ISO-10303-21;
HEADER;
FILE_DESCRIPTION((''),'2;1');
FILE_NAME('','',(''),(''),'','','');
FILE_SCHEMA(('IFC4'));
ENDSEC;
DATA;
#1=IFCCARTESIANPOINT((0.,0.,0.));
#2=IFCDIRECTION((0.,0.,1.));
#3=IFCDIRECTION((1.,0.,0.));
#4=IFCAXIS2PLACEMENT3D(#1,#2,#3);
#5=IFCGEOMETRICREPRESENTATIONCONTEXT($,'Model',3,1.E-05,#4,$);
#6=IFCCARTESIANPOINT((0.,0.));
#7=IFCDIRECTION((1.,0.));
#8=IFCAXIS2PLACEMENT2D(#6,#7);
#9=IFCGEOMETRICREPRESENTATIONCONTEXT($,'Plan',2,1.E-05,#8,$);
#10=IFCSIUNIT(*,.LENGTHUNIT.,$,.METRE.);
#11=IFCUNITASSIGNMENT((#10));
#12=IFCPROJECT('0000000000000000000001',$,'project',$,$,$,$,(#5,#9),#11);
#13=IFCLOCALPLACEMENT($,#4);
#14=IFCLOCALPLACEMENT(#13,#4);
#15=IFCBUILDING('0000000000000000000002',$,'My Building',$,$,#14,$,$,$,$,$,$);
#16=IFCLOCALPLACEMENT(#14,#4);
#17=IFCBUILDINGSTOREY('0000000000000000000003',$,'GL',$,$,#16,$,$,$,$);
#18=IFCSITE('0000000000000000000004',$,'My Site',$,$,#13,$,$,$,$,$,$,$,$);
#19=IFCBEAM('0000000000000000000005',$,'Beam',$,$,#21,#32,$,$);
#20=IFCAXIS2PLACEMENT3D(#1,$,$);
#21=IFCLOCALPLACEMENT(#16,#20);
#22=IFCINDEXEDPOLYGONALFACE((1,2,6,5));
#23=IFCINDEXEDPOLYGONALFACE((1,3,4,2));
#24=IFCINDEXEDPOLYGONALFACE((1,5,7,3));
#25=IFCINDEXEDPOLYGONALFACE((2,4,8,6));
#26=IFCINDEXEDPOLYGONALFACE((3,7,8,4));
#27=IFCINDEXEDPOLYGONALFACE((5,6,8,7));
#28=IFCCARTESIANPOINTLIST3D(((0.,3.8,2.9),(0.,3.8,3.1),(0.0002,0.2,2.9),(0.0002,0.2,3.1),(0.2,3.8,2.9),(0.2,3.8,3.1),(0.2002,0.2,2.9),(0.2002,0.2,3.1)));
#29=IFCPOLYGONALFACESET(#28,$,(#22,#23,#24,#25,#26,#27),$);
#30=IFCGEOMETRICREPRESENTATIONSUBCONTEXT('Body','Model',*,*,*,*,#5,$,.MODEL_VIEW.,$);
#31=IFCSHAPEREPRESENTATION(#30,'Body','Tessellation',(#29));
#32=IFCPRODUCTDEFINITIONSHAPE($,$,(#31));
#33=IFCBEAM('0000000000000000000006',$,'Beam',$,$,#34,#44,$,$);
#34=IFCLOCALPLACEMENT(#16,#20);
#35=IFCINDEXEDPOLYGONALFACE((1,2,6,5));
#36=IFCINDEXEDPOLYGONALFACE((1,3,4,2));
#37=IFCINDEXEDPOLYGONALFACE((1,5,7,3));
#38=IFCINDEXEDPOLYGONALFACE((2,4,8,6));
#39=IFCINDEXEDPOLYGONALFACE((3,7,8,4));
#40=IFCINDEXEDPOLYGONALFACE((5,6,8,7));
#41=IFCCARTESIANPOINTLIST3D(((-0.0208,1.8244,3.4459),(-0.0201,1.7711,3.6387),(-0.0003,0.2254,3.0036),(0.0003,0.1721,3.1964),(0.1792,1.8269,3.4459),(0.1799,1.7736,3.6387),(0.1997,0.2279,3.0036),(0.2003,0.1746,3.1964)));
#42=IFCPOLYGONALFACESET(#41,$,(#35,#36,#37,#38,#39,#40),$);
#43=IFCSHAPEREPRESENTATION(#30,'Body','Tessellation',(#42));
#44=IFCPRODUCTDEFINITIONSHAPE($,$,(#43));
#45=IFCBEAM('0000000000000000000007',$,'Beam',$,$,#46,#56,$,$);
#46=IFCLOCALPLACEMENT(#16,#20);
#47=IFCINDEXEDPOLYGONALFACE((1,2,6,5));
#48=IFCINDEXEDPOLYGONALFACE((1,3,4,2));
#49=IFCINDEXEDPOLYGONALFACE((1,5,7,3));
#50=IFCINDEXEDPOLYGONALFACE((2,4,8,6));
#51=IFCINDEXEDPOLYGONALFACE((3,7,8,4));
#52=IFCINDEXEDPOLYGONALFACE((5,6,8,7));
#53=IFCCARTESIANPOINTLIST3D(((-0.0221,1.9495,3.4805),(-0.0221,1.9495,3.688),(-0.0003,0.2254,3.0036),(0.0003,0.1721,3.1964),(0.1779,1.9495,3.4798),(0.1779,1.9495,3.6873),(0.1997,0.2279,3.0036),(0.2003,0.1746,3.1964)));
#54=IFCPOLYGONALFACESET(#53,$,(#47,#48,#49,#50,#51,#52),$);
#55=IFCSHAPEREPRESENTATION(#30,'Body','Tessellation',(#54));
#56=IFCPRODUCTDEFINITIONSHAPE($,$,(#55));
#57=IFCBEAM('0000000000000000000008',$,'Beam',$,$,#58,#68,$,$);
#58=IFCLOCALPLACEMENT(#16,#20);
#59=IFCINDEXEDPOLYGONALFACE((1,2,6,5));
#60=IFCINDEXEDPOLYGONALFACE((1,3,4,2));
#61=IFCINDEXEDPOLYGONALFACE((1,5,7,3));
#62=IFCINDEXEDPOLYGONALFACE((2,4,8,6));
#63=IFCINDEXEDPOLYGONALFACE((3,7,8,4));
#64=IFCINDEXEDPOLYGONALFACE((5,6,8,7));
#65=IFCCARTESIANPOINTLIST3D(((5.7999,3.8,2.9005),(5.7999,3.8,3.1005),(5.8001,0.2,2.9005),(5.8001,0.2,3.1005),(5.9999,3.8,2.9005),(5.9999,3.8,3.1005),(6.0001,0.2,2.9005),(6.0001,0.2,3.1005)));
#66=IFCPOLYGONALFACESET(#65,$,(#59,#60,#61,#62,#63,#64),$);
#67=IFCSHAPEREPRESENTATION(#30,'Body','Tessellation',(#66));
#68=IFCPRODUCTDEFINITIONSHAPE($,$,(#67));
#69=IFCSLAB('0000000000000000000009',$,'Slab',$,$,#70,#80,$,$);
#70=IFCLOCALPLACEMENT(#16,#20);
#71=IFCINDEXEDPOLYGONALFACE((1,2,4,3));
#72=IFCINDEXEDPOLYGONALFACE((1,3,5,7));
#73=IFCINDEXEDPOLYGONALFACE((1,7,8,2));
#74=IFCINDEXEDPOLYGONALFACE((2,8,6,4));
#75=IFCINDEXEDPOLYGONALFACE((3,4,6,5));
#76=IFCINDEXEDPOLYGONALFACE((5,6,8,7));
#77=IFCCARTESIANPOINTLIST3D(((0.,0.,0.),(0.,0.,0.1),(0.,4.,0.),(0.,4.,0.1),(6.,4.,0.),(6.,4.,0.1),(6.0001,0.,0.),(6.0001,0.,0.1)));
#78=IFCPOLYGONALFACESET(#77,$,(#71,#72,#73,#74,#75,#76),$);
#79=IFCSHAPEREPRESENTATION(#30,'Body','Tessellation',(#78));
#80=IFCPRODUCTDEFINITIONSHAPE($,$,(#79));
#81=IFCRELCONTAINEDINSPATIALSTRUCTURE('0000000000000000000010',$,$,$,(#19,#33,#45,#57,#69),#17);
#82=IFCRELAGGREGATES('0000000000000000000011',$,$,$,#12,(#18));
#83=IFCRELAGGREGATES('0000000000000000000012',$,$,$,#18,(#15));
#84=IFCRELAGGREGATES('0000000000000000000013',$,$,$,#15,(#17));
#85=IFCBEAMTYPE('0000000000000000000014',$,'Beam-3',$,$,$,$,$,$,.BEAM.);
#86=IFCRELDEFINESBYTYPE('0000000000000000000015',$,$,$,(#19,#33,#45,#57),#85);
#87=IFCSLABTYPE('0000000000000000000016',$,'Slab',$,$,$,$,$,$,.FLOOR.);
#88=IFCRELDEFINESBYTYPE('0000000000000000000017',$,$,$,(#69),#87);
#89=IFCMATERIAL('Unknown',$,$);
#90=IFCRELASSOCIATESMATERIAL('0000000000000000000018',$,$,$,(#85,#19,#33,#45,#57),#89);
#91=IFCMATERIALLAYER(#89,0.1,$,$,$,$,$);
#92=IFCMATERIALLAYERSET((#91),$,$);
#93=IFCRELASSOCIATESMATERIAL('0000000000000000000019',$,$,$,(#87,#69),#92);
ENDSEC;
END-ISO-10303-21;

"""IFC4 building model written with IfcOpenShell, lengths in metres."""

from ifc_helpers import new_model, si_unit, frame, origin_with_axes, origin_2d_with_axis, place, context, subcontext, project, spatial, indexed_curve, rectangle, outline, extrude, clip, halfspace, material, layer, layer_set, layer_usage, material_profile, profile_set, profile_usage, type_object, element, save


model = new_model("IFC4")

# Units and contexts
model_context = context("Model", 3, precision=1e-05, world=origin_with_axes())
plan_context = context("Plan", 2, precision=1e-05, world=origin_2d_with_axis())
body_context = subcontext(model_context, "Body", "Model", "MODEL_VIEW")
ifc_project = project(units=[si_unit("LENGTHUNIT", "METRE")], contexts=[model_context, plan_context])

# Site, building, storey
site_placement = place(None, origin_with_axes())
site = spatial("IfcSite", under=ifc_project, at=site_placement, Name="My Site")
building_placement = place(site_placement, origin_with_axes())
building = spatial("IfcBuilding", under=site, at=building_placement, Name="My Building")
storey_placement = place(building_placement, origin_with_axes())
storey = spatial("IfcBuildingStorey", under=building, at=storey_placement, Name="GL")

# Shared definitions
ifc_material = material(Name="Unknown")

# Beams
ifc_material_profile_1 = material_profile(ifc_material, rectangle(XDim=0.2, YDim=0.2))
ifc_profile_set_1 = profile_set([ifc_material_profile_1])
beam_type_1 = type_object("IfcBeamType", Name="Beam-3", PredefinedType="BEAM", material=ifc_profile_set_1)
ifc_profile_usage_1 = profile_usage(ifc_profile_set_1, cardinal=5)
beam_1_placement = place(storey_placement, frame((0.1002, 0.2, 3.0), z_axis=(-0.000043, 1.0, 0.0), x_axis=(-1.0, -0.000043, 0.0)))
element("IfcBeam", 1, at=beam_1_placement, inside=storey, type_object=beam_type_1, material=ifc_profile_usage_1, Name="Beam", context=body_context, shape_type="SweptSolid", body=[
    extrude(rectangle(XDim=0.2, YDim=0.2), origin_with_axes(), (0.0, 0.0, 1.0), 3.6),
])
ifc_profile_usage_2 = profile_usage(ifc_profile_set_1, cardinal=5)
beam_2_placement = place(storey_placement, frame((0.0796, 1.799, 3.5423), z_axis=(0.012309, -0.963737, -0.266571), x_axis=(0.999918, 0.012771, 0.0)))
element("IfcBeam", 2, at=beam_2_placement, inside=storey, type_object=beam_type_1, material=ifc_profile_usage_2, Name="Beam", context=body_context, shape_type="SweptSolid", body=[
    extrude(rectangle(XDim=0.2, YDim=0.2), origin_with_axes(), (0.0, 0.0, 1.0), 1.6592),
])
ifc_profile_usage_3 = profile_usage(ifc_profile_set_1, cardinal=5)
beam_3_placement = place(storey_placement, frame((0.0755, 2.1422, 3.6372), z_axis=(0.012161, -0.963739, -0.266571), x_axis=(0.99992, 0.012617, 0.0)))
element("IfcBeam", 3, at=beam_3_placement, inside=storey, type_object=beam_type_1, material=ifc_profile_usage_3, Name="Beam", context=body_context, shape_type="Clipping", body=[
    clip(extrude(rectangle(XDim=0.2, YDim=0.2), origin_with_axes(), (0.0, 0.0, 1.0), 2.0153), halfspace(frame((-0.0003, 0.0, 0.2), z_axis=(0.012617, -0.26655, -0.963739), x_axis=(-0.998882, -0.047283, 0.0)), False)),
])
ifc_profile_usage_4 = profile_usage(ifc_profile_set_1, cardinal=5)
beam_4_placement = place(storey_placement, frame((5.9001, 0.2, 3.0005), z_axis=(-0.000043, 1.0, 0.0), x_axis=(-1.0, -0.000043, 0.0)))
element("IfcBeam", 4, at=beam_4_placement, inside=storey, type_object=beam_type_1, material=ifc_profile_usage_4, Name="Beam", context=body_context, shape_type="SweptSolid", body=[
    extrude(rectangle(XDim=0.2, YDim=0.2), origin_with_axes(), (0.0, 0.0, 1.0), 3.6),
])

# Slab
ifc_layer = layer(ifc_material, 0.1)
ifc_layer_set = layer_set([ifc_layer])
ifc_layer_usage = layer_usage(ifc_layer_set, "AXIS3", "POSITIVE", -0.1)
slab_type = type_object("IfcSlabType", Name="Slab", PredefinedType="FLOOR", material=ifc_layer_set)
slab_placement = place(storey_placement, frame((0.0, 0.0, 0.1), z_axis=(0.0, 0.0, 1.0), x_axis=(1.0, 0.0, 0.0)))
element("IfcSlab", 5, at=slab_placement, inside=storey, type_object=slab_type, material=ifc_layer_usage, Name="Slab", context=body_context, shape_type="SweptSolid", body=[
    extrude(outline(indexed_curve([(0.0, 0.0), (6.0001, 0.0), (6.0, 4.0), (0.0, 4.0), (0.0, 0.0)])), frame((0.0, 0.0, -0.1), z_axis=(0.0, 0.0, 1.0), x_axis=(1.0, 0.0, 0.0)), (0.0, 0.0, 1.0), 0.1),
])

save(model, "model.ifc")
